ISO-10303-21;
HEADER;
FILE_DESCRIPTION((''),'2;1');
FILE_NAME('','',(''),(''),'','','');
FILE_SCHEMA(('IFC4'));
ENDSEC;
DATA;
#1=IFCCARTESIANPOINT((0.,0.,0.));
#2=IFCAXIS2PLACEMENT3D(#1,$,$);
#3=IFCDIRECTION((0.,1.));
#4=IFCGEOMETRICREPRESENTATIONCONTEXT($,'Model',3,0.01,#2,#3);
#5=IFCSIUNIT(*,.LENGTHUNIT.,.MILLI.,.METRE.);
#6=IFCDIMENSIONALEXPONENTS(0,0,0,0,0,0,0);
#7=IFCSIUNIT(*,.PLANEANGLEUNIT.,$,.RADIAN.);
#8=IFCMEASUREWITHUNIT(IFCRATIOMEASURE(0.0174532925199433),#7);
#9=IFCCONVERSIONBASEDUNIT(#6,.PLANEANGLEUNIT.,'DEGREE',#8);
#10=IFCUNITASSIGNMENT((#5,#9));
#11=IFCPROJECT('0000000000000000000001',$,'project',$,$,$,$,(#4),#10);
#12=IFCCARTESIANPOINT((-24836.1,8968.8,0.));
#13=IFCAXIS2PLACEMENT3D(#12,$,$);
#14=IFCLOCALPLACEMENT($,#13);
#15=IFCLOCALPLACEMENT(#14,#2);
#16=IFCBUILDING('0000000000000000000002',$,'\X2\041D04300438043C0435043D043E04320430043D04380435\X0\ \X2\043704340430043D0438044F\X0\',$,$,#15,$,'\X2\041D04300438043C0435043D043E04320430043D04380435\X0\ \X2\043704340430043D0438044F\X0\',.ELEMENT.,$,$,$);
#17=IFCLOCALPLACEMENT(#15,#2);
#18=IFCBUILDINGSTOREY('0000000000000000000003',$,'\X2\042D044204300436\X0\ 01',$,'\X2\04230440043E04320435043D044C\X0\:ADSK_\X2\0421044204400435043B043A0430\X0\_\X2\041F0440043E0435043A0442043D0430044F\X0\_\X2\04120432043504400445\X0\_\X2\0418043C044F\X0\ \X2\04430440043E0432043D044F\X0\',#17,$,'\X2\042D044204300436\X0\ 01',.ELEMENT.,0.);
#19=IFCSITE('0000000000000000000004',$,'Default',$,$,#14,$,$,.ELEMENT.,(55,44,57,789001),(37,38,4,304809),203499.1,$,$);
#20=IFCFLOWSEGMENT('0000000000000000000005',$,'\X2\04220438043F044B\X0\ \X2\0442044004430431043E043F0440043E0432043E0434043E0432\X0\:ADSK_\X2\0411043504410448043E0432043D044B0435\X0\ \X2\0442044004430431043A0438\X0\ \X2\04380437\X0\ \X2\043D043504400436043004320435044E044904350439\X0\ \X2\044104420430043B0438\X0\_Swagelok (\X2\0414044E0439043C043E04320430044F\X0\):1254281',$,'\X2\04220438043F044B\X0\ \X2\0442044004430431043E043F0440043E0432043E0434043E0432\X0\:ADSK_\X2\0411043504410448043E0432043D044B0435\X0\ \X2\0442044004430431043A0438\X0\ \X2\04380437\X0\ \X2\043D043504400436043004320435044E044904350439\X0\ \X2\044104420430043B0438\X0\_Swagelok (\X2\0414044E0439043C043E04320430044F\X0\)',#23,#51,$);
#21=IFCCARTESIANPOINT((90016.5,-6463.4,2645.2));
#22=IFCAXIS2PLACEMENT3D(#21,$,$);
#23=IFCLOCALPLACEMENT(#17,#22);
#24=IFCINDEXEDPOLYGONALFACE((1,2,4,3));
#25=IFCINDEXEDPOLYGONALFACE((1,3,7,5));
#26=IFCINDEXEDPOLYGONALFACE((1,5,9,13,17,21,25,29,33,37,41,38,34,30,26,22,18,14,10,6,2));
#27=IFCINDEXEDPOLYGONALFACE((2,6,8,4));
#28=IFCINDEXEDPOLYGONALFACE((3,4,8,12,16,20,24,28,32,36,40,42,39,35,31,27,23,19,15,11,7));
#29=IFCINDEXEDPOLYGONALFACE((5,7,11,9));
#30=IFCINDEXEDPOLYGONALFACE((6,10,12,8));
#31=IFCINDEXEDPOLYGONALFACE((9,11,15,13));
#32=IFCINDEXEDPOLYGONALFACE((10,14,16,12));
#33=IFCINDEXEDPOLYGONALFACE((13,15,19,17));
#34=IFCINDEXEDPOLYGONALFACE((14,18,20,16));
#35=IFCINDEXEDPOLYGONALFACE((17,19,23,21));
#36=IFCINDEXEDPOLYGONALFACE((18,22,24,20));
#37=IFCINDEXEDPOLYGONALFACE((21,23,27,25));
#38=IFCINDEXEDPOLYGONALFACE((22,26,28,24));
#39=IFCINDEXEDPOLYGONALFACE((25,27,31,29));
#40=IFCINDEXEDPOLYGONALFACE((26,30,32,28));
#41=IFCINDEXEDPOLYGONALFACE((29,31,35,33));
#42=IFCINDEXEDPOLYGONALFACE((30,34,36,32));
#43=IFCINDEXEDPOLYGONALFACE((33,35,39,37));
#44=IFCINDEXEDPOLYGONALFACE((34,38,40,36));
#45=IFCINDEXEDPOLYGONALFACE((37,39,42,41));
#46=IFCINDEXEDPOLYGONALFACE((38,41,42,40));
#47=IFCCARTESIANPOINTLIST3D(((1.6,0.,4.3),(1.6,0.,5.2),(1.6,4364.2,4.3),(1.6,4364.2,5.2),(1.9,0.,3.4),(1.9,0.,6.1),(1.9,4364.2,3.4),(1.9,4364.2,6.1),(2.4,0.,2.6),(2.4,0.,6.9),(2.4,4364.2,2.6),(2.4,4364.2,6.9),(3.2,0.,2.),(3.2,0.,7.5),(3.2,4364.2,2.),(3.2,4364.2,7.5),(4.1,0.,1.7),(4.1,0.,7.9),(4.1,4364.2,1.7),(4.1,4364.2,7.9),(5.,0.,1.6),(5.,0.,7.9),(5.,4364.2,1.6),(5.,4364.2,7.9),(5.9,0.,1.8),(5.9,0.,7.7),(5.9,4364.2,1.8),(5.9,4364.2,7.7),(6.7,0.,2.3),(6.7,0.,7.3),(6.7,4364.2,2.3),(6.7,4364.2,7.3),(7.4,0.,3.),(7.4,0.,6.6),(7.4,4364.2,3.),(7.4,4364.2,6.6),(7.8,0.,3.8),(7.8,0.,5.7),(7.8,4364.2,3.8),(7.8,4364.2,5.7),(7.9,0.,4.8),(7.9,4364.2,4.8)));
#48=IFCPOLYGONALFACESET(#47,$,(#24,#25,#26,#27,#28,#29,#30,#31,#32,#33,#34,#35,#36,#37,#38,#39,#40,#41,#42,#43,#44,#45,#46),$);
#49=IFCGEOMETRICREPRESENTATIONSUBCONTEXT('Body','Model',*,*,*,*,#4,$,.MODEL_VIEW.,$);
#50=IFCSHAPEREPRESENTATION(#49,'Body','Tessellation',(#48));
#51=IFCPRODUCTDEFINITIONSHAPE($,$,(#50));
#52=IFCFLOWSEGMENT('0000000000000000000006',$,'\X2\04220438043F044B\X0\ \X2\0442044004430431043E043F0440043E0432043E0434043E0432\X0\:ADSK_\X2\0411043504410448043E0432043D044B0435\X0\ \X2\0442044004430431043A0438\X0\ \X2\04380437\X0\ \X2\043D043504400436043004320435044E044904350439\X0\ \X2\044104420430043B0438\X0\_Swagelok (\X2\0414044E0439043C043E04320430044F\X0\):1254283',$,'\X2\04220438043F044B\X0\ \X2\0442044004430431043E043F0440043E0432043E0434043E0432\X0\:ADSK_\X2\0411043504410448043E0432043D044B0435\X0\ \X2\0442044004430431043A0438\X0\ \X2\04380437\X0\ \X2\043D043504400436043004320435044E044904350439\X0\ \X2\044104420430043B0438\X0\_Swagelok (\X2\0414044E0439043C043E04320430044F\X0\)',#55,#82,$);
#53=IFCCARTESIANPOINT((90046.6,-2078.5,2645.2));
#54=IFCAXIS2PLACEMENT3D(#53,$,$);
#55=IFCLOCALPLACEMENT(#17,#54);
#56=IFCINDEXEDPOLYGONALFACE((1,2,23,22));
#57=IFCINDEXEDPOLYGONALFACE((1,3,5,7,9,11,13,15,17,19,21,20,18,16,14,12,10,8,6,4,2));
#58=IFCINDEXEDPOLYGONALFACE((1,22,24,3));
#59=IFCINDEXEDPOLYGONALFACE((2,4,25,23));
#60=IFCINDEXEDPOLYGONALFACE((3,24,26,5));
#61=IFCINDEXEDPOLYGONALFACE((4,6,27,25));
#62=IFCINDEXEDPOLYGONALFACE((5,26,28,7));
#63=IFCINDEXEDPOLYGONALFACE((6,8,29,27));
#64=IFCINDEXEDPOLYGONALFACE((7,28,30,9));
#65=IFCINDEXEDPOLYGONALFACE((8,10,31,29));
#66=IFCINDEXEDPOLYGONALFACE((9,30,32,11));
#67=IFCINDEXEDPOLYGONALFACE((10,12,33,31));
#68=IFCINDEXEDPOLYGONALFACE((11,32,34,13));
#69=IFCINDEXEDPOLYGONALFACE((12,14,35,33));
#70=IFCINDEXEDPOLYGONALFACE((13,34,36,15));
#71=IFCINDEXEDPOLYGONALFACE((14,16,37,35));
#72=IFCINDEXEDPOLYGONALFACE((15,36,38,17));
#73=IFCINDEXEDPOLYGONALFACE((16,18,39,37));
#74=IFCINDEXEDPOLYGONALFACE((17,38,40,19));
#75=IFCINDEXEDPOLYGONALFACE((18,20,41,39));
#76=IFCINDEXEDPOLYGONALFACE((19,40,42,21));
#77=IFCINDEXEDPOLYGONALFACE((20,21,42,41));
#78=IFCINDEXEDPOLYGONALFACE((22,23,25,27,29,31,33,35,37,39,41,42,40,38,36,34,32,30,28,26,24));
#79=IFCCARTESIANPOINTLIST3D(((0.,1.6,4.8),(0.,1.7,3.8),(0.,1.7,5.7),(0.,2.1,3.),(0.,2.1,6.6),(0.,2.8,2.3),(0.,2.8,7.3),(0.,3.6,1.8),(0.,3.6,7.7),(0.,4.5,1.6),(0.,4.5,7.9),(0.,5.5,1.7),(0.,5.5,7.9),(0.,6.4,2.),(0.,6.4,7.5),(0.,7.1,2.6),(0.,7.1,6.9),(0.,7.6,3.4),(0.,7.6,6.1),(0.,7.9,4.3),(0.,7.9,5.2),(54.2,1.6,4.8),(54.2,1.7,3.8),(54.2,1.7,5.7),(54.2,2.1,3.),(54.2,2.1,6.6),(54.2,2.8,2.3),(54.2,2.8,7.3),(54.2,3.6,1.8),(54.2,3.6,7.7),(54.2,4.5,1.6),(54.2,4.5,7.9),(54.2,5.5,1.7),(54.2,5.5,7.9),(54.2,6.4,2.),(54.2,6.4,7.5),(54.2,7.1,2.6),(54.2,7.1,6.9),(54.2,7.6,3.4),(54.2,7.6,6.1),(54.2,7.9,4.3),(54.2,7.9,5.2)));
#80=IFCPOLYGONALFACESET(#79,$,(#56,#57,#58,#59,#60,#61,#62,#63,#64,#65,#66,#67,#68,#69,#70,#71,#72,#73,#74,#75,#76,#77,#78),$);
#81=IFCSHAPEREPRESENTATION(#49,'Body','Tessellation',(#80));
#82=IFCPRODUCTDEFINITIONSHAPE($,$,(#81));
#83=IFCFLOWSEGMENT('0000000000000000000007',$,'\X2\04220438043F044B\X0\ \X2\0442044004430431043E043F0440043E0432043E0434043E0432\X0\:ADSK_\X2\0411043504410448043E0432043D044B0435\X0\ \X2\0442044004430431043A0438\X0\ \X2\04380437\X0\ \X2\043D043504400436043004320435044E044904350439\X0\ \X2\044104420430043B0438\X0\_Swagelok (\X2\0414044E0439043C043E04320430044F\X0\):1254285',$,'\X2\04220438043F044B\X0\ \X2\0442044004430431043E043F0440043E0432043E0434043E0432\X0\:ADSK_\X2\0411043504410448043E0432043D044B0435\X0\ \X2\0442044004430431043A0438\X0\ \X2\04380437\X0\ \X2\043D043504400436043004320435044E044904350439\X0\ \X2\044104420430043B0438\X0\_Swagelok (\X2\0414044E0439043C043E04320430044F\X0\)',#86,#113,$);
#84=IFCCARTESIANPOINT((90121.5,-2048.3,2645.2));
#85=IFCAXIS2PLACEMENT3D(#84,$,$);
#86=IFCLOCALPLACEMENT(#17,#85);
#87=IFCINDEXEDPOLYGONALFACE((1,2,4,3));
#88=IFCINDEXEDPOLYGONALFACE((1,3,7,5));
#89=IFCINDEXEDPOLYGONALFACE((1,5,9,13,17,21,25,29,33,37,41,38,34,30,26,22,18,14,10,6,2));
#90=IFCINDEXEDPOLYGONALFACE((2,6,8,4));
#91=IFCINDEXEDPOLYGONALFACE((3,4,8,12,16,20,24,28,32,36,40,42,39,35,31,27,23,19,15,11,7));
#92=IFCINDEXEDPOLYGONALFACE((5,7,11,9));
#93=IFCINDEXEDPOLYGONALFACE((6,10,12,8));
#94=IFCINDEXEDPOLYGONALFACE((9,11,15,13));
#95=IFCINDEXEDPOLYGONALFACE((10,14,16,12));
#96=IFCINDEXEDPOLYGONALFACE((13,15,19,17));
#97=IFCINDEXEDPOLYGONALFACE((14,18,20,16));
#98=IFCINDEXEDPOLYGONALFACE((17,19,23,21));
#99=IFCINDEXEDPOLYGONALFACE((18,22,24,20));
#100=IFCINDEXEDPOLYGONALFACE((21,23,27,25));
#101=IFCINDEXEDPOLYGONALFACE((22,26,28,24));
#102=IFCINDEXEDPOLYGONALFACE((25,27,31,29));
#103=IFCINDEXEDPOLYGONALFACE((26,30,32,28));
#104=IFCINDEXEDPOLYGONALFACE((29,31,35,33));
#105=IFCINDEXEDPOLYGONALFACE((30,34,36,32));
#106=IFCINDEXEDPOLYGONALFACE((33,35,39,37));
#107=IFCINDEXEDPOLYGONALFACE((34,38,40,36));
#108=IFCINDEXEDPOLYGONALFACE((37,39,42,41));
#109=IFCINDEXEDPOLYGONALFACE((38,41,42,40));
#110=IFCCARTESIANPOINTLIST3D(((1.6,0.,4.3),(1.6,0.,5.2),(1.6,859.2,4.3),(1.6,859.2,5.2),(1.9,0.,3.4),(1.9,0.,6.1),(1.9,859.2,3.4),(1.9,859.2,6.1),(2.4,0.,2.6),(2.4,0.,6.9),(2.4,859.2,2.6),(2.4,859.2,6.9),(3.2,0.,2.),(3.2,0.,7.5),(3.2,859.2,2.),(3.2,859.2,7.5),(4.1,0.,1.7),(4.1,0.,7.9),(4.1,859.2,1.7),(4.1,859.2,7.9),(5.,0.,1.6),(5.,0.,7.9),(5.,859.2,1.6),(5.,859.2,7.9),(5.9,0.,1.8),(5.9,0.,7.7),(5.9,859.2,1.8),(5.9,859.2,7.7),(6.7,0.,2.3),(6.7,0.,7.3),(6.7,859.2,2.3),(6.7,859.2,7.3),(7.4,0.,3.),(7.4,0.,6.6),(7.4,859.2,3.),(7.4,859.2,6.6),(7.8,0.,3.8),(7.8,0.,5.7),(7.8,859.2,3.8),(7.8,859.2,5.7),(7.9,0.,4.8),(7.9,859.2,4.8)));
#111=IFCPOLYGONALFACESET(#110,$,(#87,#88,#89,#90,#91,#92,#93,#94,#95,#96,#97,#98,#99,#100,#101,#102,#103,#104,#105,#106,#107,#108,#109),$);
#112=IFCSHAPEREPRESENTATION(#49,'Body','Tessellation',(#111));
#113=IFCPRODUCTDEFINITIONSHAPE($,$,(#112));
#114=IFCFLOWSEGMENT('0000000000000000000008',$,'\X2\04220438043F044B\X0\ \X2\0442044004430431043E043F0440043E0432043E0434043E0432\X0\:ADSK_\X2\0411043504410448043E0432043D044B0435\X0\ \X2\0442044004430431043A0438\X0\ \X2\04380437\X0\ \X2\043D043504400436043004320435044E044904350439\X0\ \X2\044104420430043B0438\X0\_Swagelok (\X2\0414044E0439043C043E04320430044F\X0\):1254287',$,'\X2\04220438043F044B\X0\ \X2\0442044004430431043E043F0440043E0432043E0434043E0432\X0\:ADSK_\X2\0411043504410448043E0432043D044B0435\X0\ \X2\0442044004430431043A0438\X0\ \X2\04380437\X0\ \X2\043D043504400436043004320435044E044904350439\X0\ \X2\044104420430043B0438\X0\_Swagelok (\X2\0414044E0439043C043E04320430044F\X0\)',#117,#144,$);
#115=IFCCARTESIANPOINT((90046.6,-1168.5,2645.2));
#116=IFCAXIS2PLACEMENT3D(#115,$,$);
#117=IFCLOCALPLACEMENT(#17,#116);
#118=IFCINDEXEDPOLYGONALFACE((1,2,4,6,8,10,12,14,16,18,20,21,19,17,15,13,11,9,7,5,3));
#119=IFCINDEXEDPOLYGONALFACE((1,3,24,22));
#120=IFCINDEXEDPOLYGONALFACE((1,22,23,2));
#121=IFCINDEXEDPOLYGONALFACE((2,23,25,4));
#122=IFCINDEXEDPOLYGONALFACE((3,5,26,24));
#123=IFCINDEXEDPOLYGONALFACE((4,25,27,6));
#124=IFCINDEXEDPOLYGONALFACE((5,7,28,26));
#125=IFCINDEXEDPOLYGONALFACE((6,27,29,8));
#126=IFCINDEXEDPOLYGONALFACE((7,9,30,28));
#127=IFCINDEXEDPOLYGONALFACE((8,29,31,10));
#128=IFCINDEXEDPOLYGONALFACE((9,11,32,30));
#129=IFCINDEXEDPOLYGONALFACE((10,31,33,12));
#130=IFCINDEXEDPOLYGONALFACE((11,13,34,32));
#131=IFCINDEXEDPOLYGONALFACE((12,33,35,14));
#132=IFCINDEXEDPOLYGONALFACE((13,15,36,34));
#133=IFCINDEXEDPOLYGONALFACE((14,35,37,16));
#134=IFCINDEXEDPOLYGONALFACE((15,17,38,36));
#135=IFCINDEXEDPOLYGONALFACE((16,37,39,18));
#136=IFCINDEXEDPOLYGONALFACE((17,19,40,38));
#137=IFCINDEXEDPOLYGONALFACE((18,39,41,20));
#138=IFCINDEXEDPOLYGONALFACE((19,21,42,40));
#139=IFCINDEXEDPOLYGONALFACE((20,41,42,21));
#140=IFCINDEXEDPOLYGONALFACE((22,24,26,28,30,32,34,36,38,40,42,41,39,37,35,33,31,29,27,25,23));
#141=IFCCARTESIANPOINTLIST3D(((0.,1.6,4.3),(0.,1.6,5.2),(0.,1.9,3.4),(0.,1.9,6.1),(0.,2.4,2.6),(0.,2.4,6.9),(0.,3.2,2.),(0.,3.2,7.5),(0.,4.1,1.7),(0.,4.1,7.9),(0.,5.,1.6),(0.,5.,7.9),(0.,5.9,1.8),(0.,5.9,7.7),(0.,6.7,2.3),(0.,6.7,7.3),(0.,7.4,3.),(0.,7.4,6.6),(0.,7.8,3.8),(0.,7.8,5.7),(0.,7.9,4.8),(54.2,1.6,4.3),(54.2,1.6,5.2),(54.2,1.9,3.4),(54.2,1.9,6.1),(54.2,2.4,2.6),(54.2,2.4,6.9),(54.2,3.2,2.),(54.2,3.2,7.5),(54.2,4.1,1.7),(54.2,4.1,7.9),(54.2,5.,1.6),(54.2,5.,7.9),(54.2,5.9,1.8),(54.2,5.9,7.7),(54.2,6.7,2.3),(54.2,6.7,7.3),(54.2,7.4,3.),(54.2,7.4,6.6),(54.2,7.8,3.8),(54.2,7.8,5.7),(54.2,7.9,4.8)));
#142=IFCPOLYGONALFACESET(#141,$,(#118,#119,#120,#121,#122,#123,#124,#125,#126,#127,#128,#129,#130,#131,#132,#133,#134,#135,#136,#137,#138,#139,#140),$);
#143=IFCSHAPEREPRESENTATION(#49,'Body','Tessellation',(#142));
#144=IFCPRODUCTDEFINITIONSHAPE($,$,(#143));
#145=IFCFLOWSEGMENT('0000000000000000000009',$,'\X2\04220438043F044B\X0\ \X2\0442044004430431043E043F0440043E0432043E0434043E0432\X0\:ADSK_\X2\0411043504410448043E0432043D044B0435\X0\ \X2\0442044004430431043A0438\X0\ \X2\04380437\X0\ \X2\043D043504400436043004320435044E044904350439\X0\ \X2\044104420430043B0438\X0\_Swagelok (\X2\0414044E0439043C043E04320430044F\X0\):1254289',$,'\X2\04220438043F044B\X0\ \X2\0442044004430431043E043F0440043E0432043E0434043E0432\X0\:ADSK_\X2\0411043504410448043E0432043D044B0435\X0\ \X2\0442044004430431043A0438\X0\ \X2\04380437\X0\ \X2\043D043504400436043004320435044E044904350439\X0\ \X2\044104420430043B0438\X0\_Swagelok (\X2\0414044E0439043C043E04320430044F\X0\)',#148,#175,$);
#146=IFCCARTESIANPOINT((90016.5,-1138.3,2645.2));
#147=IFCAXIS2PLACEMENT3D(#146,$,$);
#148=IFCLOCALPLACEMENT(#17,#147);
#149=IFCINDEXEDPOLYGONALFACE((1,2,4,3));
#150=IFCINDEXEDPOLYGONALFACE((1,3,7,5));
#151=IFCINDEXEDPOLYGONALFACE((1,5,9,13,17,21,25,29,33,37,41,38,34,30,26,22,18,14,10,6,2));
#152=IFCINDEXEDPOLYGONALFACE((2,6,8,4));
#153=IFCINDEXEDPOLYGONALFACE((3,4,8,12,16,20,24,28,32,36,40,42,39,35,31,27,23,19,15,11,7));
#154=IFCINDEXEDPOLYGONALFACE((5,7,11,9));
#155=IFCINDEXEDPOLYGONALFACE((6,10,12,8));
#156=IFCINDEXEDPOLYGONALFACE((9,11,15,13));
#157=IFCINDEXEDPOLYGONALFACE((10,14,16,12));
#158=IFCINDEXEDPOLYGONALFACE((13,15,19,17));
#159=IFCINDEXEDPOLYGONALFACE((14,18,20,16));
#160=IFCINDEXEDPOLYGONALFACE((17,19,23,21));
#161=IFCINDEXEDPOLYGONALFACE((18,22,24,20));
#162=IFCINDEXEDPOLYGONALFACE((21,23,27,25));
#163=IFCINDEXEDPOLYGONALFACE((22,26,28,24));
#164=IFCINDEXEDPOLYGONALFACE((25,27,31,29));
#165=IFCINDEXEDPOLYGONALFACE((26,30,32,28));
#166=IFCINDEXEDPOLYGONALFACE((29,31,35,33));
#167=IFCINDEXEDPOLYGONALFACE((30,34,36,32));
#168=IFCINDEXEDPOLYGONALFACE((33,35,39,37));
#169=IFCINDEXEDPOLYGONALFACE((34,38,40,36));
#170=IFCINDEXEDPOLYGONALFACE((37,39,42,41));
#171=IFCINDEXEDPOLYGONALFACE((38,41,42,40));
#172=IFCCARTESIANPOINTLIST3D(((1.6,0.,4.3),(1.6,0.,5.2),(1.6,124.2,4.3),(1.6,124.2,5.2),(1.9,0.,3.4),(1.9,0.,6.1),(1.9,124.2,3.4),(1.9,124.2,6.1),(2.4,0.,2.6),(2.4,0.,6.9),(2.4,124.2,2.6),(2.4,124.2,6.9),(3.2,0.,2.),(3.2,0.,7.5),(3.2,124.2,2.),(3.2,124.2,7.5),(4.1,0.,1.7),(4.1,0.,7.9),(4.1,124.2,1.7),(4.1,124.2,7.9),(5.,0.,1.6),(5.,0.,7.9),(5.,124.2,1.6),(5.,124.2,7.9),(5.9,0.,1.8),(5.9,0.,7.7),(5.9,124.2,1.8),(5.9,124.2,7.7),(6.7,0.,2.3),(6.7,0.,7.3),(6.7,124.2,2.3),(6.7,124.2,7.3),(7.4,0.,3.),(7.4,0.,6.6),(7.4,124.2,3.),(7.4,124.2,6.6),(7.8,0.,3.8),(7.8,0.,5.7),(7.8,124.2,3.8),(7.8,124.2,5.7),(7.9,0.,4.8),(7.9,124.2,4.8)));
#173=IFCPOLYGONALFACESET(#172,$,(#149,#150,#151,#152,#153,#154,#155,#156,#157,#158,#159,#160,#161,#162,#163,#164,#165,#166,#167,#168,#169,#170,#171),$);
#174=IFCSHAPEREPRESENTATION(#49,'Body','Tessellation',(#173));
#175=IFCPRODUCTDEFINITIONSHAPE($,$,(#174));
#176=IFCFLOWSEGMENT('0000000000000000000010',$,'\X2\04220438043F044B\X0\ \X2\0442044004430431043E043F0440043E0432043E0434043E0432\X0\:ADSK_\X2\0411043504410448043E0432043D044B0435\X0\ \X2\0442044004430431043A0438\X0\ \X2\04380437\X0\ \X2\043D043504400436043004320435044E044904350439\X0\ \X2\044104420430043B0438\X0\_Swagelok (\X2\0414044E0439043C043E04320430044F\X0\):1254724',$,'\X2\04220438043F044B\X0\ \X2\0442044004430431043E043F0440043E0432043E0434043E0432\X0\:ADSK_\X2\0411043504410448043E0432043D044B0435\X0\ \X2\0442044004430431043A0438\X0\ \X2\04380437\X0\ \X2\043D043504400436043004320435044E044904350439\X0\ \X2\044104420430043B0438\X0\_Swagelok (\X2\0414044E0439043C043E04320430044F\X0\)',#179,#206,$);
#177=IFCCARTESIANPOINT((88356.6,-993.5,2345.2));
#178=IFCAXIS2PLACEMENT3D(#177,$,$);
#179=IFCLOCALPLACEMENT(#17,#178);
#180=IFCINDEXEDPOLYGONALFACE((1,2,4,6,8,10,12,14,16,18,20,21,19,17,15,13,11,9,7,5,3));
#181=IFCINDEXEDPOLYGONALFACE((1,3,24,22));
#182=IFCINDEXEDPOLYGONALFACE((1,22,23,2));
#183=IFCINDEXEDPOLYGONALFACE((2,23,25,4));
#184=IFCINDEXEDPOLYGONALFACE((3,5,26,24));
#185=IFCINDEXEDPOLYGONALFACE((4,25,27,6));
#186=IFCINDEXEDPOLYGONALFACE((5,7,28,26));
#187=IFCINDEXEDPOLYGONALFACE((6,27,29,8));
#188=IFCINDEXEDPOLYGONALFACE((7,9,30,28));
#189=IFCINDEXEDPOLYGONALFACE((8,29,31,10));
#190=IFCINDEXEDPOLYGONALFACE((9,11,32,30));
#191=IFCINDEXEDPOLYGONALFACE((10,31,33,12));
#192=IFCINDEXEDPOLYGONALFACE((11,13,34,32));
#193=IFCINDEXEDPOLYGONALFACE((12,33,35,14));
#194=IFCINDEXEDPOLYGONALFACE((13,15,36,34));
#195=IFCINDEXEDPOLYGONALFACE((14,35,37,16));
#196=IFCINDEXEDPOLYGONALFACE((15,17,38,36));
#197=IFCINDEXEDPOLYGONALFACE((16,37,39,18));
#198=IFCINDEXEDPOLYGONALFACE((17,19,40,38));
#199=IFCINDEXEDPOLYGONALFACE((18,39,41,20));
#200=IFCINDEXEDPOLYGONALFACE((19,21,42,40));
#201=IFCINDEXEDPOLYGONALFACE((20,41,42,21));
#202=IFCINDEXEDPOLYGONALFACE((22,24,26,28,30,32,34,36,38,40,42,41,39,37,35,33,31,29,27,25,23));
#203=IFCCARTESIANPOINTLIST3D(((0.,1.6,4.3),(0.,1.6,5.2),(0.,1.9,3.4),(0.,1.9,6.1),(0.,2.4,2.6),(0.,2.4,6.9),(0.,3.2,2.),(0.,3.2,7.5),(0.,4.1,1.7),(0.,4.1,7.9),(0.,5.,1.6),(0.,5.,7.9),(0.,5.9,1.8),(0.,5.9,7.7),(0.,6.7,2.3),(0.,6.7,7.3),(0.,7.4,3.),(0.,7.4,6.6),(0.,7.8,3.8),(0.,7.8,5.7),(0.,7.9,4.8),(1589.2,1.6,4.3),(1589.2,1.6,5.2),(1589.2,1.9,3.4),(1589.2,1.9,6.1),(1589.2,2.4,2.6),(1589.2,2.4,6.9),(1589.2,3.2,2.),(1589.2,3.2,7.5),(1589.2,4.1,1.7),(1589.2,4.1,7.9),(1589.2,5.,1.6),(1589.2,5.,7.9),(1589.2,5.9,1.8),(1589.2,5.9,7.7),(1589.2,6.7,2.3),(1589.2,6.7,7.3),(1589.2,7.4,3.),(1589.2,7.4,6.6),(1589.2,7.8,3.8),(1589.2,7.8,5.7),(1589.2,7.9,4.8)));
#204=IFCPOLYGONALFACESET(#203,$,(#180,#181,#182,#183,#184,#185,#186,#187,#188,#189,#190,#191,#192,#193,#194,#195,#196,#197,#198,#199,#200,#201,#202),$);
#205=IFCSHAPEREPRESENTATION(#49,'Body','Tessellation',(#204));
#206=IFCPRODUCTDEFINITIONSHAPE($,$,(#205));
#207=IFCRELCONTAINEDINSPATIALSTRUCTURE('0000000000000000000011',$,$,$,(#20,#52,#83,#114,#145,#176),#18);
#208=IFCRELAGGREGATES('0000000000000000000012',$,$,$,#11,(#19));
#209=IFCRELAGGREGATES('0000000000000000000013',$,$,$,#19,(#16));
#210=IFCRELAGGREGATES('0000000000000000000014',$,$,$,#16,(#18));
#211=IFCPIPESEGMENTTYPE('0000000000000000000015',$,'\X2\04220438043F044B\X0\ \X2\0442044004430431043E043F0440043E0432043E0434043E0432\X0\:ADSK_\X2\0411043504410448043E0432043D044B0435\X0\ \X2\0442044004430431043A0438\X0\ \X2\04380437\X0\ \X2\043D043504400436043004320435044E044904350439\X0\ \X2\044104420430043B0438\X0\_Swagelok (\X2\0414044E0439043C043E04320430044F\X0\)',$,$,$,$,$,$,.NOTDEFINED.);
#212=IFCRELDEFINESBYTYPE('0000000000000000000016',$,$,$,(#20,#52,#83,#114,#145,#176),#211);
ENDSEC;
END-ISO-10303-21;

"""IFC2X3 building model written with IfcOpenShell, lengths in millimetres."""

from ifc_helpers import new_model, entity, si_unit, converted_unit, direction, frame, origin, origin_2d_with_axis, place, context, subcontext, project, spatial, circle, extrude, type_object, element, save


model = new_model("IFC2X3")

# Units and contexts
model_context = context("Model", 3, precision=0.01, world=origin(), true_north=direction((0.0, 1.0)))
body_context = subcontext(model_context, "Body", "Model", "MODEL_VIEW")
ifc_project = project(units=[si_unit("LENGTHUNIT", "METRE", prefix="MILLI"), converted_unit("PLANEANGLEUNIT", "DEGREE", entity("IfcRatioMeasure", 0.0174532925199433), si_unit("PLANEANGLEUNIT", "RADIAN"), dimensions=[0, 0, 0, 0, 0, 0, 0])], contexts=[model_context])

# Site, building, storey
site_placement = place(None, frame((-24836.1, 8968.8, 0.0)))
site = spatial("IfcSite", under=ifc_project, at=site_placement, Name="Default", CompositionType="ELEMENT", RefLatitude=(55, 44, 57, 789001), RefLongitude=(37, 38, 4, 304809), RefElevation=203499.1)
building_placement = place(site_placement, origin())
building = spatial("IfcBuilding", under=site, at=building_placement, Name="Наименование здания", LongName="Наименование здания", CompositionType="ELEMENT")
storey_placement = place(building_placement, origin())
storey = spatial("IfcBuildingStorey", under=building, at=storey_placement, Name="Этаж 01", ObjectType="Уровень:ADSK_Стрелка_Проектная_Вверх_Имя уровня", LongName="Этаж 01", CompositionType="ELEMENT", Elevation=0.0)

# Flow segments
pipe_segment_type_1 = type_object("IfcPipeSegmentType", Name="Типы трубопроводов:ADSK_Бесшовные трубки из нержавеющей стали_Swagelok (Дюймовая)", PredefinedType="NOTDEFINED")
flow_segment_1_placement = place(storey_placement, frame((90016.5, -6463.4, 2645.2)))
element("IfcFlowSegment", 1, at=flow_segment_1_placement, inside=storey, type_object=pipe_segment_type_1, Name="Типы трубопроводов:ADSK_Бесшовные трубки из нержавеющей стали_Swagelok (Дюймовая):1254281", ObjectType="Типы трубопроводов:ADSK_Бесшовные трубки из нержавеющей стали_Swagelok (Дюймовая)", context=body_context, shape_type="SweptSolid", body=[
    extrude(circle(Radius=3.2, at=origin_2d_with_axis()), frame((4.8, 0.0, 4.8), z_axis=(0.0, 1.0, 0.0), x_axis=(1.0, 0.0, 0.0)), (0.0, 0.0, 1.0), 4364.2),
])
flow_segment_2_placement = place(storey_placement, frame((90046.6, -2078.5, 2645.2)))
element("IfcFlowSegment", 2, at=flow_segment_2_placement, inside=storey, type_object=pipe_segment_type_1, Name="Типы трубопроводов:ADSK_Бесшовные трубки из нержавеющей стали_Swagelok (Дюймовая):1254283", ObjectType="Типы трубопроводов:ADSK_Бесшовные трубки из нержавеющей стали_Swagelok (Дюймовая)", context=body_context, shape_type="SweptSolid", body=[
    extrude(circle(Radius=3.2, at=origin_2d_with_axis()), frame((0.0, 4.8, 4.8), z_axis=(1.0, 0.0, 0.0), x_axis=(0.0, -1.0, 0.0)), (0.0, 0.0, 1.0), 54.2),
])
flow_segment_3_placement = place(storey_placement, frame((90121.5, -2048.3, 2645.2)))
element("IfcFlowSegment", 3, at=flow_segment_3_placement, inside=storey, type_object=pipe_segment_type_1, Name="Типы трубопроводов:ADSK_Бесшовные трубки из нержавеющей стали_Swagelok (Дюймовая):1254285", ObjectType="Типы трубопроводов:ADSK_Бесшовные трубки из нержавеющей стали_Swagelok (Дюймовая)", context=body_context, shape_type="SweptSolid", body=[
    extrude(circle(Radius=3.2, at=origin_2d_with_axis()), frame((4.8, 0.0, 4.8), z_axis=(0.0, 1.0, 0.0), x_axis=(1.0, 0.0, 0.0)), (0.0, 0.0, 1.0), 859.2),
])
flow_segment_4_placement = place(storey_placement, frame((90046.6, -1168.5, 2645.2)))
element("IfcFlowSegment", 4, at=flow_segment_4_placement, inside=storey, type_object=pipe_segment_type_1, Name="Типы трубопроводов:ADSK_Бесшовные трубки из нержавеющей стали_Swagelok (Дюймовая):1254287", ObjectType="Типы трубопроводов:ADSK_Бесшовные трубки из нержавеющей стали_Swagelok (Дюймовая)", context=body_context, shape_type="SweptSolid", body=[
    extrude(circle(Radius=3.2, at=origin_2d_with_axis()), frame((0.0, 4.8, 4.8), z_axis=(1.0, 0.0, 0.0), x_axis=(0.0, 1.0, 0.0)), (0.0, 0.0, 1.0), 54.2),
])
flow_segment_5_placement = place(storey_placement, frame((90016.5, -1138.3, 2645.2)))
element("IfcFlowSegment", 5, at=flow_segment_5_placement, inside=storey, type_object=pipe_segment_type_1, Name="Типы трубопроводов:ADSK_Бесшовные трубки из нержавеющей стали_Swagelok (Дюймовая):1254289", ObjectType="Типы трубопроводов:ADSK_Бесшовные трубки из нержавеющей стали_Swagelok (Дюймовая)", context=body_context, shape_type="SweptSolid", body=[
    extrude(circle(Radius=3.2, at=origin_2d_with_axis()), frame((4.8, 0.0, 4.8), z_axis=(0.0, 1.0, 0.0), x_axis=(1.0, 0.0, 0.0)), (0.0, 0.0, 1.0), 124.2),
])
flow_segment_6_placement = place(storey_placement, frame((88356.6, -993.5, 2345.2)))
element("IfcFlowSegment", 6, at=flow_segment_6_placement, inside=storey, type_object=pipe_segment_type_1, Name="Типы трубопроводов:ADSK_Бесшовные трубки из нержавеющей стали_Swagelok (Дюймовая):1254724", ObjectType="Типы трубопроводов:ADSK_Бесшовные трубки из нержавеющей стали_Swagelok (Дюймовая)", context=body_context, shape_type="SweptSolid", body=[
    extrude(circle(Radius=3.2, at=origin_2d_with_axis()), frame((0.0, 4.8, 4.8), z_axis=(1.0, 0.0, 0.0), x_axis=(0.0, 1.0, 0.0)), (0.0, 0.0, 1.0), 1589.2),
])

save(model, "model.ifc")
